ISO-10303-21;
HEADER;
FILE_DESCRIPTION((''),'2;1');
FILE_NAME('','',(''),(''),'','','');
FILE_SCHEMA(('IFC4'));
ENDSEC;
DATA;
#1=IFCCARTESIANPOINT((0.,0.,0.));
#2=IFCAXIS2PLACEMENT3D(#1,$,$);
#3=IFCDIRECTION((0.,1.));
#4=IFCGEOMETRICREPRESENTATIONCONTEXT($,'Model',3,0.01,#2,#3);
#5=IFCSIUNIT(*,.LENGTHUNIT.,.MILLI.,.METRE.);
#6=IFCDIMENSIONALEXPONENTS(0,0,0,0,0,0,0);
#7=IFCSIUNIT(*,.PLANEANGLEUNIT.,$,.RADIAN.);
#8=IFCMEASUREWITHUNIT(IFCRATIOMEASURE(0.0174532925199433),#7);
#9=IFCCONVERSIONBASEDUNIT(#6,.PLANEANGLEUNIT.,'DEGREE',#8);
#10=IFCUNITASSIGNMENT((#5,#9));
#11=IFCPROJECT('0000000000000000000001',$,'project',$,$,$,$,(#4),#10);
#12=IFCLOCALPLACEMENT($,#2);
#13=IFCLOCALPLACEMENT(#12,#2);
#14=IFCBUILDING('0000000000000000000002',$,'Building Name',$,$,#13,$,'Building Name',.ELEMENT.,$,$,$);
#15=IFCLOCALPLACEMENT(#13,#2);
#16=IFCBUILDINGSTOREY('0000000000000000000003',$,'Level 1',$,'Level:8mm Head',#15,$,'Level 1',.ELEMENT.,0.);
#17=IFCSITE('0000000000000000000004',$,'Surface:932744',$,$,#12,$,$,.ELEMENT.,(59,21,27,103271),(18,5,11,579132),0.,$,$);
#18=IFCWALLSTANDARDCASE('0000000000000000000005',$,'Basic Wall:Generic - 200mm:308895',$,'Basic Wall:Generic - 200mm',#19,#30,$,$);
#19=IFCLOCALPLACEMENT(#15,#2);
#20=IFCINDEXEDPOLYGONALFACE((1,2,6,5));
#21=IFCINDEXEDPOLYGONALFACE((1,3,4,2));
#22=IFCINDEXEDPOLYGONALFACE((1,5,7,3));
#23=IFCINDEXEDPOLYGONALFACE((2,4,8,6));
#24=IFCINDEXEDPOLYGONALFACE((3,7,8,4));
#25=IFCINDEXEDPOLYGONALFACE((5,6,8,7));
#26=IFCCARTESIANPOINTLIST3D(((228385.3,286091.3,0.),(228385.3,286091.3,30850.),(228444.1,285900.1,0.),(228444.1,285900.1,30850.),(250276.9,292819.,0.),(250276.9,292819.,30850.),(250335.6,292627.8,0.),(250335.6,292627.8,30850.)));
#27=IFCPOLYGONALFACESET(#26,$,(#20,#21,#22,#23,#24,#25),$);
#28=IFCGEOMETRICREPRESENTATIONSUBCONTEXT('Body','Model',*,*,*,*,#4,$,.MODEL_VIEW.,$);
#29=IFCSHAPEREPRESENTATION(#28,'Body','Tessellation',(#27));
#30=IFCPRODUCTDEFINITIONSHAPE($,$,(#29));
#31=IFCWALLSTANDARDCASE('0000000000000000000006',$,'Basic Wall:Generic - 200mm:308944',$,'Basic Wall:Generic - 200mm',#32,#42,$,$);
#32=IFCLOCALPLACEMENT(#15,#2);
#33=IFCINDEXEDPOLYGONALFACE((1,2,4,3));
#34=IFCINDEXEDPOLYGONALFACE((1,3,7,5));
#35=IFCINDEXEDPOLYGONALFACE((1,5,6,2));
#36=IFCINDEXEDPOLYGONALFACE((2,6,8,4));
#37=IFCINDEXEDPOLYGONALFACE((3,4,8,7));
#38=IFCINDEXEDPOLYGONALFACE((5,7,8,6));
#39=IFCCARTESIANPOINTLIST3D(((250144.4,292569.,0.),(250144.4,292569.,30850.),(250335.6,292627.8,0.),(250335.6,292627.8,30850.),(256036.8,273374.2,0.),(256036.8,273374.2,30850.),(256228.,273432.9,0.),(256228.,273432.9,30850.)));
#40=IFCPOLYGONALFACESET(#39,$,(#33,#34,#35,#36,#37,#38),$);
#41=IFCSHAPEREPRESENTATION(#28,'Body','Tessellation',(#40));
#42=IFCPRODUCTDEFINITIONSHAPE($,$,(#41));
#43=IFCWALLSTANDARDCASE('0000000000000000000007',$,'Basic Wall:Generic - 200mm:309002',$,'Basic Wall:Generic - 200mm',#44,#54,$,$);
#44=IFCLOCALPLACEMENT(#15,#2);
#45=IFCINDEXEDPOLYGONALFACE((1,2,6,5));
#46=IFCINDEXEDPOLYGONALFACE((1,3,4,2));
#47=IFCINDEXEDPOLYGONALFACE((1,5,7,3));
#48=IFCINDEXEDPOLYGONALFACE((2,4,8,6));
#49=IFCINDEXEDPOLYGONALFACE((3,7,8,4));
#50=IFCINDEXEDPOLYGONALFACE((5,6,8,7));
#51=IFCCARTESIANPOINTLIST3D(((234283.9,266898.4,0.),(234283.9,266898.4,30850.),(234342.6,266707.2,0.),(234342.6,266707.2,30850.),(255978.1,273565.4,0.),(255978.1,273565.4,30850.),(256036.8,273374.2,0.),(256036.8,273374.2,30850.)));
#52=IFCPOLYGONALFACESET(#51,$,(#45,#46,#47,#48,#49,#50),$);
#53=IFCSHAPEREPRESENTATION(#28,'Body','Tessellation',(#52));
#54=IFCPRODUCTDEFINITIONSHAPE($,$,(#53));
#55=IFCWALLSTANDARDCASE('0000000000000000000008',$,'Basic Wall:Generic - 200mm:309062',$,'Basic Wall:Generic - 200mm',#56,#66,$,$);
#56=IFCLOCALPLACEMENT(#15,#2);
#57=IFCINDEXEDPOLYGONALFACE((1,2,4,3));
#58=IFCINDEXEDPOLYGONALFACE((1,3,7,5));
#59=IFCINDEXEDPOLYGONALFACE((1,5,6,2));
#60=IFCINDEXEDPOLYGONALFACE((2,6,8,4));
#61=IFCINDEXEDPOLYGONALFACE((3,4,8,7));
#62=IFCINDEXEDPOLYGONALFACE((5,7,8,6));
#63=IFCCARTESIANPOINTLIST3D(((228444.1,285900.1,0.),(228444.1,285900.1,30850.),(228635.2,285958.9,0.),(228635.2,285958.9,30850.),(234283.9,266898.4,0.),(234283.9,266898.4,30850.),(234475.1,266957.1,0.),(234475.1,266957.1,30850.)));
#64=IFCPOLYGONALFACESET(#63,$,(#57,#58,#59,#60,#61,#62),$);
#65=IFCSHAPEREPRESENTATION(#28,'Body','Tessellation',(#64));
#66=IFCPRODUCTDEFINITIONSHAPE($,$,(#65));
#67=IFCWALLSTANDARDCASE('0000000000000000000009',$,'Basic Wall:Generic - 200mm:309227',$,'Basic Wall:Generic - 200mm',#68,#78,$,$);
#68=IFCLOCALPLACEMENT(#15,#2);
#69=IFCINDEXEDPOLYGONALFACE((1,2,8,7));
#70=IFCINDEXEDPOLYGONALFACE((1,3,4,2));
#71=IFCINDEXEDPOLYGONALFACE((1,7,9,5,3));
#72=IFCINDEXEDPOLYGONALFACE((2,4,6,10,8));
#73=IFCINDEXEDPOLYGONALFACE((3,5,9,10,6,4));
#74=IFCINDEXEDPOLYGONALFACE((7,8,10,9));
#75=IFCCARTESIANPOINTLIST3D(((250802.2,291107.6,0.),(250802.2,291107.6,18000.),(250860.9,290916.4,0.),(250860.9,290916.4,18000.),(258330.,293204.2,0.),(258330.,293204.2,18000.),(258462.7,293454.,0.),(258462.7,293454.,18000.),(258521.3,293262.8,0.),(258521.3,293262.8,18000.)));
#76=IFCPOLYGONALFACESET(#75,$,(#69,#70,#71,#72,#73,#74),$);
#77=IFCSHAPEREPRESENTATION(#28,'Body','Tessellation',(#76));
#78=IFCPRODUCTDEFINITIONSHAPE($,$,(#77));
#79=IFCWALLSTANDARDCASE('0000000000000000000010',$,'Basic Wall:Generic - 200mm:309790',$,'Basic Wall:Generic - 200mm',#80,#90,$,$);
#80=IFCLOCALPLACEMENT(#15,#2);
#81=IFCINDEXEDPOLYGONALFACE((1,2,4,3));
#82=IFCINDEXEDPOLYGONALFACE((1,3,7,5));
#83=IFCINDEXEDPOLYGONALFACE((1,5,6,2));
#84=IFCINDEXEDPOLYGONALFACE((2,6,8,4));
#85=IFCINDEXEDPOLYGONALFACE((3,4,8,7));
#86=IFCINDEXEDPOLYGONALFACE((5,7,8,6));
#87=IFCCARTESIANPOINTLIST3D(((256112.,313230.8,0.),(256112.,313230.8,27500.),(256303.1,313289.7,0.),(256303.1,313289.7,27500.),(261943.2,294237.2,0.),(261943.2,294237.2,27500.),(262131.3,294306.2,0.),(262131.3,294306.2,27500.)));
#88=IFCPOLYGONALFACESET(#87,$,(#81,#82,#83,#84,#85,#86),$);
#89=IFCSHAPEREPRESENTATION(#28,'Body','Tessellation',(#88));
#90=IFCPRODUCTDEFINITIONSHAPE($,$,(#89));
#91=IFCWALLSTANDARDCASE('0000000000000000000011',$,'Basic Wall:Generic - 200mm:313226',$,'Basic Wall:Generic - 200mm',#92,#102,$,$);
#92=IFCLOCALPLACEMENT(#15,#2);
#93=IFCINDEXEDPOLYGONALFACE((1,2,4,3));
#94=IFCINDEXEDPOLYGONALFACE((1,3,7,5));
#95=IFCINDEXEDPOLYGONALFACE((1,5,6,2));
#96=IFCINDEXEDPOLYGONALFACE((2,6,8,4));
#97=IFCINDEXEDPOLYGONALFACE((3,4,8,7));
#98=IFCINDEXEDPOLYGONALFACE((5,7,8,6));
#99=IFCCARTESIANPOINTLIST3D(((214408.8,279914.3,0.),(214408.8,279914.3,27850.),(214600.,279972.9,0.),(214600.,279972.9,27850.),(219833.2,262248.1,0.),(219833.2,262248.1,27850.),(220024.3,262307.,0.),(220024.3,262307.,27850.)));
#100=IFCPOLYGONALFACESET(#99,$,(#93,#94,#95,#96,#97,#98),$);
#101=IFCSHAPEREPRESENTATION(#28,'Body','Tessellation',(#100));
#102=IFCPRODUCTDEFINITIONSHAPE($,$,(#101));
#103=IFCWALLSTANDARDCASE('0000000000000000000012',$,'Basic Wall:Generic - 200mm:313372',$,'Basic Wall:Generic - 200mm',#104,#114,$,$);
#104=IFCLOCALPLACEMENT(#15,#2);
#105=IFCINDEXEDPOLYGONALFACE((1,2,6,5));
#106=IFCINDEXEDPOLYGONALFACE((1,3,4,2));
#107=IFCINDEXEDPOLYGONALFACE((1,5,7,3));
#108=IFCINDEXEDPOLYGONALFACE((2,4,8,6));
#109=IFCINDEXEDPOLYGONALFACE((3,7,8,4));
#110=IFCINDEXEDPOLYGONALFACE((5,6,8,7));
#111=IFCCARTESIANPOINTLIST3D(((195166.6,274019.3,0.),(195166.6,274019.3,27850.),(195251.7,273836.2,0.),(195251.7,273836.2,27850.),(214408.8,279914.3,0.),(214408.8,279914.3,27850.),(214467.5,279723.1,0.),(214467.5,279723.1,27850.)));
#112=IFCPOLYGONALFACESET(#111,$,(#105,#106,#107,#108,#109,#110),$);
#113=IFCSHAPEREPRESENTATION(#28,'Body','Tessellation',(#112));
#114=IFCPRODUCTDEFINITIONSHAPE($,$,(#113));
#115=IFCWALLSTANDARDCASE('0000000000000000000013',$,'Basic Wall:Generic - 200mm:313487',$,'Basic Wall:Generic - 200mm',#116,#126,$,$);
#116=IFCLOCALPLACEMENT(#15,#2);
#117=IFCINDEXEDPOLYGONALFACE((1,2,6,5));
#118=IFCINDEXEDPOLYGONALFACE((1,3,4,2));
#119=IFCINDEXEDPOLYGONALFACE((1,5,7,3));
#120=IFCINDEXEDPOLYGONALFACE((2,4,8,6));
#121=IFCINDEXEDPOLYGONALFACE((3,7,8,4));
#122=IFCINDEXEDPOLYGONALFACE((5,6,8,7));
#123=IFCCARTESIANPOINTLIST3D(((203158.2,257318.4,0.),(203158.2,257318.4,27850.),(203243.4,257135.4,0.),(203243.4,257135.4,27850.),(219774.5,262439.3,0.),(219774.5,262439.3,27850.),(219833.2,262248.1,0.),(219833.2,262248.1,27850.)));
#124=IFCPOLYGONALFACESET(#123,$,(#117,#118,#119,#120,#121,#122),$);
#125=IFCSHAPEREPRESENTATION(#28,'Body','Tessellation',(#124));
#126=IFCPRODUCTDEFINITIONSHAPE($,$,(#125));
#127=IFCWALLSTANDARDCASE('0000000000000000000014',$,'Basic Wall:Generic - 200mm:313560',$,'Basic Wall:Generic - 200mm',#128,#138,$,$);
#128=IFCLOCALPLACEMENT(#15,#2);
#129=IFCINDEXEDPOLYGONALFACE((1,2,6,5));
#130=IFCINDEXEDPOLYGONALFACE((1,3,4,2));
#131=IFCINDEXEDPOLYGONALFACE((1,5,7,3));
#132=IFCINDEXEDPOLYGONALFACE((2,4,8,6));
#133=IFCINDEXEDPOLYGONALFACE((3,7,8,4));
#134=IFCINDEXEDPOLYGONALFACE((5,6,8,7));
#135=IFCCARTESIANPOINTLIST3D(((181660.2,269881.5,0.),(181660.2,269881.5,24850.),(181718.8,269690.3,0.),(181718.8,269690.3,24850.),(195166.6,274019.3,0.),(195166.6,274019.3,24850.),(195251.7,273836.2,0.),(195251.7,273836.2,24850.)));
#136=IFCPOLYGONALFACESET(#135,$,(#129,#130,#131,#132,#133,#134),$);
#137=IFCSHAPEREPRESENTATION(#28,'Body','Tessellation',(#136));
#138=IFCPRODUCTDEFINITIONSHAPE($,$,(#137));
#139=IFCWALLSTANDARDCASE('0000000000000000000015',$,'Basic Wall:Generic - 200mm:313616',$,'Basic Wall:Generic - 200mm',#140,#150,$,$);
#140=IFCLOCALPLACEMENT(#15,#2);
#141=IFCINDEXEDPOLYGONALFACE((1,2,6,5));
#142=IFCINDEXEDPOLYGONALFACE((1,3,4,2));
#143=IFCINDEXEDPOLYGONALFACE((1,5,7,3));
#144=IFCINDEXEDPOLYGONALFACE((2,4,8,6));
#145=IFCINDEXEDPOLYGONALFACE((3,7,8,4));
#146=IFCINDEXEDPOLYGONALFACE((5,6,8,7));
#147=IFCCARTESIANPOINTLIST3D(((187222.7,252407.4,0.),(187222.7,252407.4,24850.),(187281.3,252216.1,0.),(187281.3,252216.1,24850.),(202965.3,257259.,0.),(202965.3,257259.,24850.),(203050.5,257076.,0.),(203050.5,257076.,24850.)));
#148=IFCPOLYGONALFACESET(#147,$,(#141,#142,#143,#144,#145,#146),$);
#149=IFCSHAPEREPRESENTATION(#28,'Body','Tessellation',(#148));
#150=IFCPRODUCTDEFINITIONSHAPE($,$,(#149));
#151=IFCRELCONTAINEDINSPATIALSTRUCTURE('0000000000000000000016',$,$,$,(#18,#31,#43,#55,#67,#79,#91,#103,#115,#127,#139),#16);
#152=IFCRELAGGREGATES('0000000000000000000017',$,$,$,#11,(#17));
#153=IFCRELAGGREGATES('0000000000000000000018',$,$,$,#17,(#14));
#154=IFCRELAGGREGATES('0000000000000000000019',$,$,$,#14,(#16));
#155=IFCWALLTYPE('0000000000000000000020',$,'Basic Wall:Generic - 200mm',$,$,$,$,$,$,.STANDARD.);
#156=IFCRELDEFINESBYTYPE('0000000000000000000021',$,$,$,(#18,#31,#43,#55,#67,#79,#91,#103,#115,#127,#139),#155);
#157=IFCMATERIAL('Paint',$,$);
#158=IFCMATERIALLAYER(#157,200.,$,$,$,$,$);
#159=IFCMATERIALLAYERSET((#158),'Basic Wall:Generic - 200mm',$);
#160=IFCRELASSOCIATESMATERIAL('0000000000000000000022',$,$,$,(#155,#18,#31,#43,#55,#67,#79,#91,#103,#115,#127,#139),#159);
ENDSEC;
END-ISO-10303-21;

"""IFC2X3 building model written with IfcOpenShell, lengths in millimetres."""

from ifc_helpers import new_model, entity, si_unit, converted_unit, direction, frame, frame_2d, origin, place, context, subcontext, project, spatial, polyline, rectangle, outline, extrude, clip, bounded_halfspace, material, layer, layer_set, layer_usage, type_object, element, save


model = new_model("IFC2X3")

# Units and contexts
model_context = context("Model", 3, precision=0.01, world=origin(), true_north=direction((0.0, 1.0)))
body_context = subcontext(model_context, "Body", "Model", "MODEL_VIEW")
ifc_project = project(units=[si_unit("LENGTHUNIT", "METRE", prefix="MILLI"), converted_unit("PLANEANGLEUNIT", "DEGREE", entity("IfcRatioMeasure", 0.0174532925199433), si_unit("PLANEANGLEUNIT", "RADIAN"), dimensions=[0, 0, 0, 0, 0, 0, 0])], contexts=[model_context])

# Site, building, storey
site_placement = place(None, origin())
site = spatial("IfcSite", under=ifc_project, at=site_placement, Name="Surface:932744", CompositionType="ELEMENT", RefLatitude=(59, 21, 27, 103271), RefLongitude=(18, 5, 11, 579132), RefElevation=0.0)
building_placement = place(site_placement, origin())
building = spatial("IfcBuilding", under=site, at=building_placement, Name="Building Name", LongName="Building Name", CompositionType="ELEMENT")
storey_placement = place(building_placement, origin())
storey = spatial("IfcBuildingStorey", under=building, at=storey_placement, Name="Level 1", ObjectType="Level:8mm Head", LongName="Level 1", CompositionType="ELEMENT", Elevation=0.0)

# Walls
ifc_material_1 = material(Name="Paint")
ifc_layer_1 = layer(ifc_material_1, 200.0)
ifc_layer_set_1 = layer_set([ifc_layer_1], Name="Basic Wall:Generic - 200mm")
ifc_layer_usage_1 = layer_usage(ifc_layer_set_1, "AXIS2", "NEGATIVE", 100.0)
wall_type_1 = type_object("IfcWallType", Name="Basic Wall:Generic - 200mm", PredefinedType="STANDARD", material=ifc_layer_set_1)
wall_1_placement = place(storey_placement, frame((228414.7, 285995.7, 0.0), z_axis=(0.0, 0.0, 1.0), x_axis=(0.95588, 0.293758, 0.0)))
element("IfcWallStandardCase", 1, at=wall_1_placement, inside=storey, type_object=wall_type_1, material=ifc_layer_usage_1, Name="Basic Wall:Generic - 200mm:308895", ObjectType="Basic Wall:Generic - 200mm", context=body_context, shape_type="Clipping", body=[
    clip(extrude(outline(polyline([(22902.0, -100.0), (22902.0, 100.0), (0.0, 100.0), (0.0, -100.0), (200.0, -100.0), (22702.0, -100.0), (22902.0, -100.0)])), origin(), (0.0, 0.0, 1.0), 30850.0), bounded_halfspace(frame((0.0, -100.0, 30850.0), z_axis=(0.0, 0.0, -1.0), x_axis=(-1.0, 0.0, 0.0)), True, frame((0.0, -100.0, 30850.0), z_axis=(0.0, 0.0, -1.0), x_axis=(-1.0, 0.0, 0.0)), polyline([(0.0, 0.0), (0.0, 200.0), (-22902.0, 200.0), (-22902.0, 0.0), (-22702.0, 0.0), (-200.0, 0.0), (0.0, 0.0)]))),
])
ifc_layer_usage_2 = layer_usage(ifc_layer_set_1, "AXIS2", "NEGATIVE", 100.0)
wall_2_placement = place(storey_placement, frame((250240.0, 292598.4, 0.0), z_axis=(0.0, 0.0, 1.0), x_axis=(0.293464, -0.95597, 0.0)))
element("IfcWallStandardCase", 2, at=wall_2_placement, inside=storey, type_object=wall_type_1, material=ifc_layer_usage_2, Name="Basic Wall:Generic - 200mm:308944", ObjectType="Basic Wall:Generic - 200mm", context=body_context, shape_type="Clipping", body=[
    clip(extrude(outline(polyline([(20079.0, -100.0), (20078.9, 100.0), (19878.9, 100.0), (1790.1, 100.0), (1590.1, 100.0), (0.0, 100.0), (0.1, -100.0), (19879.0, -100.0), (20079.0, -100.0)])), origin(), (0.0, 0.0, 1.0), 30850.0), bounded_halfspace(frame((0.1, -100.0, 30850.0), z_axis=(0.0, 0.0, -1.0), x_axis=(0.000308, -1.0, 0.0)), True, frame((0.1, -100.0, 30850.0), z_axis=(0.0, 0.0, -1.0), x_axis=(0.000308, -1.0, 0.0)), polyline([(0.0, 0.0), (-200.0, 0.0), (-193.8, -20078.9), (6.2, -20078.9), (0.0, 0.0)]))),
])
ifc_layer_usage_3 = layer_usage(ifc_layer_set_1, "AXIS2", "NEGATIVE", 100.0)
wall_3_placement = place(storey_placement, frame((256007.5, 273469.8, 0.0), z_axis=(0.0, 0.0, 1.0), x_axis=(-0.95588, -0.293758, 0.0)))
element("IfcWallStandardCase", 3, at=wall_3_placement, inside=storey, type_object=wall_type_1, material=ifc_layer_usage_3, Name="Basic Wall:Generic - 200mm:309002", ObjectType="Basic Wall:Generic - 200mm", context=body_context, shape_type="Clipping", body=[
    clip(extrude(outline(polyline([(22695.6, -100.0), (22695.6, 100.0), (0.1, 100.0), (0.0, -100.0), (22495.6, -100.0), (22695.6, -100.0)])), origin(), (0.0, 0.0, 1.0), 30850.0), bounded_halfspace(frame((0.0, -100.0, 30850.0), z_axis=(0.0, 0.0, -1.0), x_axis=(1.0, 0.0, 0.0)), True, frame((0.0, -100.0, 30850.0), z_axis=(0.0, 0.0, -1.0), x_axis=(1.0, 0.0, 0.0)), polyline([(0.0, 0.0), (0.1, -200.0), (22695.6, -200.0), (22695.6, 0.0), (22495.6, 0.0), (0.0, 0.0)]))),
])
ifc_layer_usage_4 = layer_usage(ifc_layer_set_1, "AXIS2", "NEGATIVE", 100.0)
wall_4_placement = place(storey_placement, frame((234379.5, 266927.8, 0.0), z_axis=(0.0, 0.0, 1.0), x_axis=(-0.29377, 0.955876, 0.0)))
element("IfcWallStandardCase", 4, at=wall_4_placement, inside=storey, type_object=wall_type_1, material=ifc_layer_usage_4, Name="Basic Wall:Generic - 200mm:309062", ObjectType="Basic Wall:Generic - 200mm", context=body_context, shape_type="Clipping", body=[
    clip(extrude(rectangle(XDim=19878.9, YDim=200.0, at=frame_2d((9939.4, 0.0), x_axis=(-1.0, 0.0))), origin(), (0.0, 0.0, 1.0), 30850.0), bounded_halfspace(frame((0.0, -100.0, 30850.0), z_axis=(0.0, 0.0, -1.0), x_axis=(0.000012, 1.0, 0.0)), True, frame((0.0, -100.0, 30850.0), z_axis=(0.0, 0.0, -1.0), x_axis=(0.000012, 1.0, 0.0)), polyline([(0.0, 0.0), (200.0, 0.0), (200.2, 19878.9), (0.2, 19878.9), (0.0, 0.0)]))),
])
ifc_layer_usage_5 = layer_usage(ifc_layer_set_1, "AXIS2", "NEGATIVE", 100.0)
wall_5_placement = place(storey_placement, frame((250831.5, 291012.0, 0.0), z_axis=(0.0, 0.0, 1.0), x_axis=(0.956153, 0.292868, 0.0)))
element("IfcWallStandardCase", 5, at=wall_5_placement, inside=storey, type_object=wall_type_1, material=ifc_layer_usage_5, Name="Basic Wall:Generic - 200mm:309227", ObjectType="Basic Wall:Generic - 200mm", context=body_context, shape_type="SweptSolid", body=[
    extrude(outline(polyline([(8011.7, -100.0), (8011.7, 100.0), (0.0, 100.0), (0.1, -100.0), (7811.7, -100.0), (8011.7, -100.0)])), origin(), (0.0, 0.0, 1.0), 18000.0),
])
ifc_layer_usage_6 = layer_usage(ifc_layer_set_1, "AXIS2", "NEGATIVE", 100.0)
wall_6_placement = place(storey_placement, frame((256207.5, 313260.4, 0.0), z_axis=(0.0, 0.0, 1.0), x_axis=(0.29349, -0.955962, 0.0)))
element("IfcWallStandardCase", 6, at=wall_6_placement, inside=storey, type_object=wall_type_1, material=ifc_layer_usage_6, Name="Basic Wall:Generic - 200mm:309790", ObjectType="Basic Wall:Generic - 200mm", context=body_context, shape_type="SweptSolid", body=[
    extrude(outline(polyline([(19868.8, -100.0), (19858.0, 100.0), (0.0, 100.0), (0.3, -100.0), (19868.8, -100.0)])), origin(), (0.0, 0.0, 1.0), 27500.0),
])
ifc_layer_usage_7 = layer_usage(ifc_layer_set_1, "AXIS2", "NEGATIVE", 100.0)
wall_7_placement = place(storey_placement, frame((219928.8, 262277.5, 0.0), z_axis=(0.0, 0.0, 1.0), x_axis=(-0.293523, 0.955952, 0.0)))
element("IfcWallStandardCase", 7, at=wall_7_placement, inside=storey, type_object=wall_type_1, material=ifc_layer_usage_7, Name="Basic Wall:Generic - 200mm:313226", ObjectType="Basic Wall:Generic - 200mm", context=body_context, shape_type="Clipping", body=[
    clip(extrude(outline(polyline([(18480.0, -100.0), (18480.2, 100.0), (18280.2, 100.0), (200.0, 100.0), (0.0, 100.0), (0.2, -100.0), (18480.0, -100.0)])), origin(), (0.0, 0.0, 1.0), 27850.0), bounded_halfspace(frame((0.2, -100.0, 27850.0), z_axis=(0.0, 0.0, -1.0), x_axis=(-0.000633, -1.0, 0.0)), True, frame((0.2, -100.0, 27850.0), z_axis=(0.0, 0.0, -1.0), x_axis=(-0.000633, -1.0, 0.0)), polyline([(0.0, 0.0), (-200.0, 0.3), (-200.1, -199.7), (-211.6, -18279.8), (-211.7, -18479.8), (-11.7, -18479.8), (0.0, 0.0)]))),
])
ifc_layer_usage_8 = layer_usage(ifc_layer_set_1, "AXIS2", "NEGATIVE", 100.0)
wall_8_placement = place(storey_placement, frame((214438.2, 279818.7, 0.0), z_axis=(0.0, 0.0, 1.0), x_axis=(-0.956137, -0.292918, 0.0)))
element("IfcWallStandardCase", 8, at=wall_8_placement, inside=storey, type_object=wall_type_1, material=ifc_layer_usage_8, Name="Basic Wall:Generic - 200mm:313372", ObjectType="Basic Wall:Generic - 200mm", context=body_context, shape_type="Clipping", body=[
    clip(extrude(outline(polyline([(20125.1, -100.0), (20097.3, 100.0), (19895.4, 100.0), (0.0, 100.0), (0.1, -100.0), (20125.1, -100.0)])), origin(), (0.0, 0.0, 1.0), 27850.0), bounded_halfspace(frame((0.1, -100.0, 27850.0), z_axis=(0.0, 0.0, -1.0), x_axis=(-1.0, 0.0, 0.0)), True, frame((0.1, -100.0, 27850.0), z_axis=(0.0, 0.0, -1.0), x_axis=(-1.0, 0.0, 0.0)), polyline([(0.0, 0.0), (0.1, 200.0), (-20097.2, 200.0), (-20125.0, 0.0), (0.0, 0.0)]))),
])

# Walls
ifc_layer_usage_9 = layer_usage(ifc_layer_set_1, "AXIS2", "NEGATIVE", 100.0)
wall_9_placement = place(storey_placement, frame((203187.7, 257222.9, 0.0), z_axis=(0.0, 0.0, 1.0), x_axis=(0.955647, 0.294515, 0.0)))
element("IfcWallStandardCase", 9, at=wall_9_placement, inside=storey, type_object=wall_type_1, material=ifc_layer_usage_9, Name="Basic Wall:Generic - 200mm:313487", ObjectType="Basic Wall:Generic - 200mm", context=body_context, shape_type="Clipping", body=[
    clip(extrude(outline(polyline([(17387.2, -100.0), (17387.4, 100.0), (0.0, 100.0), (27.5, -100.0), (17387.2, -100.0)])), origin(), (0.0, 0.0, 1.0), 27850.0), bounded_halfspace(frame((27.5, -100.0, 27850.0), z_axis=(0.0, 0.0, -1.0), x_axis=(0.999999, -0.001671, 0.0)), True, frame((27.5, -100.0, 27850.0), z_axis=(0.0, 0.0, -1.0), x_axis=(0.999999, -0.001671, 0.0)), polyline([(0.0, 0.0), (-27.8, -200.0), (17359.6, -229.0), (17359.7, -29.0), (0.0, 0.0)]))),
])
ifc_layer_usage_10 = layer_usage(ifc_layer_set_1, "AXIS2", "NEGATIVE", 100.0)
wall_10_placement = place(storey_placement, frame((195222.5, 273931.8, 0.0), z_axis=(0.0, 0.0, 1.0), x_axis=(-0.956137, -0.292918, 0.0)))
element("IfcWallStandardCase", 10, at=wall_10_placement, inside=storey, type_object=wall_type_1, material=ifc_layer_usage_10, Name="Basic Wall:Generic - 200mm:313560", ObjectType="Basic Wall:Generic - 200mm", context=body_context, shape_type="Clipping", body=[
    clip(extrude(outline(polyline([(14153.8, -100.0), (14153.8, 100.0), (13953.8, 100.0), (0.0, 100.0), (27.8, -100.0), (14153.8, -100.0)])), origin(), (0.0, 0.0, 1.0), 24850.0), bounded_halfspace(frame((27.8, -100.0, 24850.0), z_axis=(0.0, 0.0, -1.0), x_axis=(-1.0, 0.0, 0.0)), True, frame((27.8, -100.0, 24850.0), z_axis=(0.0, 0.0, -1.0), x_axis=(-1.0, 0.0, 0.0)), polyline([(0.0, 0.0), (27.8, 200.0), (-14126.0, 200.0), (-14126.0, 0.0), (0.0, 0.0)]))),
])

# Wall
ifc_layer_usage_11 = layer_usage(ifc_layer_set_1, "AXIS2", "NEGATIVE", 100.0)
wall_11_placement = place(storey_placement, frame((187251.8, 252311.7, 0.0), z_axis=(0.0, 0.0, 1.0), x_axis=(0.955647, 0.294515, 0.0)))
element("IfcWallStandardCase", 11, at=wall_11_placement, inside=storey, type_object=wall_type_1, material=ifc_layer_usage_11, Name="Basic Wall:Generic - 200mm:313616", ObjectType="Basic Wall:Generic - 200mm", context=body_context, shape_type="Clipping", body=[
    clip(extrude(outline(polyline([(16501.1, -100.0), (16473.6, 100.0), (0.3, 100.0), (0.0, -100.0), (16501.1, -100.0)])), origin(), (0.0, 0.0, 1.0), 24850.0), bounded_halfspace(frame((0.0, -100.0, 24850.0), z_axis=(0.0, 0.0, -1.0), x_axis=(0.999999, -0.001671, 0.0)), True, frame((0.0, -100.0, 24850.0), z_axis=(0.0, 0.0, -1.0), x_axis=(0.999999, -0.001671, 0.0)), polyline([(0.0, 0.0), (0.0, -200.0), (16473.2, -227.5), (16501.1, -27.6), (0.0, 0.0)]))),
])

save(model, "model.ifc")
